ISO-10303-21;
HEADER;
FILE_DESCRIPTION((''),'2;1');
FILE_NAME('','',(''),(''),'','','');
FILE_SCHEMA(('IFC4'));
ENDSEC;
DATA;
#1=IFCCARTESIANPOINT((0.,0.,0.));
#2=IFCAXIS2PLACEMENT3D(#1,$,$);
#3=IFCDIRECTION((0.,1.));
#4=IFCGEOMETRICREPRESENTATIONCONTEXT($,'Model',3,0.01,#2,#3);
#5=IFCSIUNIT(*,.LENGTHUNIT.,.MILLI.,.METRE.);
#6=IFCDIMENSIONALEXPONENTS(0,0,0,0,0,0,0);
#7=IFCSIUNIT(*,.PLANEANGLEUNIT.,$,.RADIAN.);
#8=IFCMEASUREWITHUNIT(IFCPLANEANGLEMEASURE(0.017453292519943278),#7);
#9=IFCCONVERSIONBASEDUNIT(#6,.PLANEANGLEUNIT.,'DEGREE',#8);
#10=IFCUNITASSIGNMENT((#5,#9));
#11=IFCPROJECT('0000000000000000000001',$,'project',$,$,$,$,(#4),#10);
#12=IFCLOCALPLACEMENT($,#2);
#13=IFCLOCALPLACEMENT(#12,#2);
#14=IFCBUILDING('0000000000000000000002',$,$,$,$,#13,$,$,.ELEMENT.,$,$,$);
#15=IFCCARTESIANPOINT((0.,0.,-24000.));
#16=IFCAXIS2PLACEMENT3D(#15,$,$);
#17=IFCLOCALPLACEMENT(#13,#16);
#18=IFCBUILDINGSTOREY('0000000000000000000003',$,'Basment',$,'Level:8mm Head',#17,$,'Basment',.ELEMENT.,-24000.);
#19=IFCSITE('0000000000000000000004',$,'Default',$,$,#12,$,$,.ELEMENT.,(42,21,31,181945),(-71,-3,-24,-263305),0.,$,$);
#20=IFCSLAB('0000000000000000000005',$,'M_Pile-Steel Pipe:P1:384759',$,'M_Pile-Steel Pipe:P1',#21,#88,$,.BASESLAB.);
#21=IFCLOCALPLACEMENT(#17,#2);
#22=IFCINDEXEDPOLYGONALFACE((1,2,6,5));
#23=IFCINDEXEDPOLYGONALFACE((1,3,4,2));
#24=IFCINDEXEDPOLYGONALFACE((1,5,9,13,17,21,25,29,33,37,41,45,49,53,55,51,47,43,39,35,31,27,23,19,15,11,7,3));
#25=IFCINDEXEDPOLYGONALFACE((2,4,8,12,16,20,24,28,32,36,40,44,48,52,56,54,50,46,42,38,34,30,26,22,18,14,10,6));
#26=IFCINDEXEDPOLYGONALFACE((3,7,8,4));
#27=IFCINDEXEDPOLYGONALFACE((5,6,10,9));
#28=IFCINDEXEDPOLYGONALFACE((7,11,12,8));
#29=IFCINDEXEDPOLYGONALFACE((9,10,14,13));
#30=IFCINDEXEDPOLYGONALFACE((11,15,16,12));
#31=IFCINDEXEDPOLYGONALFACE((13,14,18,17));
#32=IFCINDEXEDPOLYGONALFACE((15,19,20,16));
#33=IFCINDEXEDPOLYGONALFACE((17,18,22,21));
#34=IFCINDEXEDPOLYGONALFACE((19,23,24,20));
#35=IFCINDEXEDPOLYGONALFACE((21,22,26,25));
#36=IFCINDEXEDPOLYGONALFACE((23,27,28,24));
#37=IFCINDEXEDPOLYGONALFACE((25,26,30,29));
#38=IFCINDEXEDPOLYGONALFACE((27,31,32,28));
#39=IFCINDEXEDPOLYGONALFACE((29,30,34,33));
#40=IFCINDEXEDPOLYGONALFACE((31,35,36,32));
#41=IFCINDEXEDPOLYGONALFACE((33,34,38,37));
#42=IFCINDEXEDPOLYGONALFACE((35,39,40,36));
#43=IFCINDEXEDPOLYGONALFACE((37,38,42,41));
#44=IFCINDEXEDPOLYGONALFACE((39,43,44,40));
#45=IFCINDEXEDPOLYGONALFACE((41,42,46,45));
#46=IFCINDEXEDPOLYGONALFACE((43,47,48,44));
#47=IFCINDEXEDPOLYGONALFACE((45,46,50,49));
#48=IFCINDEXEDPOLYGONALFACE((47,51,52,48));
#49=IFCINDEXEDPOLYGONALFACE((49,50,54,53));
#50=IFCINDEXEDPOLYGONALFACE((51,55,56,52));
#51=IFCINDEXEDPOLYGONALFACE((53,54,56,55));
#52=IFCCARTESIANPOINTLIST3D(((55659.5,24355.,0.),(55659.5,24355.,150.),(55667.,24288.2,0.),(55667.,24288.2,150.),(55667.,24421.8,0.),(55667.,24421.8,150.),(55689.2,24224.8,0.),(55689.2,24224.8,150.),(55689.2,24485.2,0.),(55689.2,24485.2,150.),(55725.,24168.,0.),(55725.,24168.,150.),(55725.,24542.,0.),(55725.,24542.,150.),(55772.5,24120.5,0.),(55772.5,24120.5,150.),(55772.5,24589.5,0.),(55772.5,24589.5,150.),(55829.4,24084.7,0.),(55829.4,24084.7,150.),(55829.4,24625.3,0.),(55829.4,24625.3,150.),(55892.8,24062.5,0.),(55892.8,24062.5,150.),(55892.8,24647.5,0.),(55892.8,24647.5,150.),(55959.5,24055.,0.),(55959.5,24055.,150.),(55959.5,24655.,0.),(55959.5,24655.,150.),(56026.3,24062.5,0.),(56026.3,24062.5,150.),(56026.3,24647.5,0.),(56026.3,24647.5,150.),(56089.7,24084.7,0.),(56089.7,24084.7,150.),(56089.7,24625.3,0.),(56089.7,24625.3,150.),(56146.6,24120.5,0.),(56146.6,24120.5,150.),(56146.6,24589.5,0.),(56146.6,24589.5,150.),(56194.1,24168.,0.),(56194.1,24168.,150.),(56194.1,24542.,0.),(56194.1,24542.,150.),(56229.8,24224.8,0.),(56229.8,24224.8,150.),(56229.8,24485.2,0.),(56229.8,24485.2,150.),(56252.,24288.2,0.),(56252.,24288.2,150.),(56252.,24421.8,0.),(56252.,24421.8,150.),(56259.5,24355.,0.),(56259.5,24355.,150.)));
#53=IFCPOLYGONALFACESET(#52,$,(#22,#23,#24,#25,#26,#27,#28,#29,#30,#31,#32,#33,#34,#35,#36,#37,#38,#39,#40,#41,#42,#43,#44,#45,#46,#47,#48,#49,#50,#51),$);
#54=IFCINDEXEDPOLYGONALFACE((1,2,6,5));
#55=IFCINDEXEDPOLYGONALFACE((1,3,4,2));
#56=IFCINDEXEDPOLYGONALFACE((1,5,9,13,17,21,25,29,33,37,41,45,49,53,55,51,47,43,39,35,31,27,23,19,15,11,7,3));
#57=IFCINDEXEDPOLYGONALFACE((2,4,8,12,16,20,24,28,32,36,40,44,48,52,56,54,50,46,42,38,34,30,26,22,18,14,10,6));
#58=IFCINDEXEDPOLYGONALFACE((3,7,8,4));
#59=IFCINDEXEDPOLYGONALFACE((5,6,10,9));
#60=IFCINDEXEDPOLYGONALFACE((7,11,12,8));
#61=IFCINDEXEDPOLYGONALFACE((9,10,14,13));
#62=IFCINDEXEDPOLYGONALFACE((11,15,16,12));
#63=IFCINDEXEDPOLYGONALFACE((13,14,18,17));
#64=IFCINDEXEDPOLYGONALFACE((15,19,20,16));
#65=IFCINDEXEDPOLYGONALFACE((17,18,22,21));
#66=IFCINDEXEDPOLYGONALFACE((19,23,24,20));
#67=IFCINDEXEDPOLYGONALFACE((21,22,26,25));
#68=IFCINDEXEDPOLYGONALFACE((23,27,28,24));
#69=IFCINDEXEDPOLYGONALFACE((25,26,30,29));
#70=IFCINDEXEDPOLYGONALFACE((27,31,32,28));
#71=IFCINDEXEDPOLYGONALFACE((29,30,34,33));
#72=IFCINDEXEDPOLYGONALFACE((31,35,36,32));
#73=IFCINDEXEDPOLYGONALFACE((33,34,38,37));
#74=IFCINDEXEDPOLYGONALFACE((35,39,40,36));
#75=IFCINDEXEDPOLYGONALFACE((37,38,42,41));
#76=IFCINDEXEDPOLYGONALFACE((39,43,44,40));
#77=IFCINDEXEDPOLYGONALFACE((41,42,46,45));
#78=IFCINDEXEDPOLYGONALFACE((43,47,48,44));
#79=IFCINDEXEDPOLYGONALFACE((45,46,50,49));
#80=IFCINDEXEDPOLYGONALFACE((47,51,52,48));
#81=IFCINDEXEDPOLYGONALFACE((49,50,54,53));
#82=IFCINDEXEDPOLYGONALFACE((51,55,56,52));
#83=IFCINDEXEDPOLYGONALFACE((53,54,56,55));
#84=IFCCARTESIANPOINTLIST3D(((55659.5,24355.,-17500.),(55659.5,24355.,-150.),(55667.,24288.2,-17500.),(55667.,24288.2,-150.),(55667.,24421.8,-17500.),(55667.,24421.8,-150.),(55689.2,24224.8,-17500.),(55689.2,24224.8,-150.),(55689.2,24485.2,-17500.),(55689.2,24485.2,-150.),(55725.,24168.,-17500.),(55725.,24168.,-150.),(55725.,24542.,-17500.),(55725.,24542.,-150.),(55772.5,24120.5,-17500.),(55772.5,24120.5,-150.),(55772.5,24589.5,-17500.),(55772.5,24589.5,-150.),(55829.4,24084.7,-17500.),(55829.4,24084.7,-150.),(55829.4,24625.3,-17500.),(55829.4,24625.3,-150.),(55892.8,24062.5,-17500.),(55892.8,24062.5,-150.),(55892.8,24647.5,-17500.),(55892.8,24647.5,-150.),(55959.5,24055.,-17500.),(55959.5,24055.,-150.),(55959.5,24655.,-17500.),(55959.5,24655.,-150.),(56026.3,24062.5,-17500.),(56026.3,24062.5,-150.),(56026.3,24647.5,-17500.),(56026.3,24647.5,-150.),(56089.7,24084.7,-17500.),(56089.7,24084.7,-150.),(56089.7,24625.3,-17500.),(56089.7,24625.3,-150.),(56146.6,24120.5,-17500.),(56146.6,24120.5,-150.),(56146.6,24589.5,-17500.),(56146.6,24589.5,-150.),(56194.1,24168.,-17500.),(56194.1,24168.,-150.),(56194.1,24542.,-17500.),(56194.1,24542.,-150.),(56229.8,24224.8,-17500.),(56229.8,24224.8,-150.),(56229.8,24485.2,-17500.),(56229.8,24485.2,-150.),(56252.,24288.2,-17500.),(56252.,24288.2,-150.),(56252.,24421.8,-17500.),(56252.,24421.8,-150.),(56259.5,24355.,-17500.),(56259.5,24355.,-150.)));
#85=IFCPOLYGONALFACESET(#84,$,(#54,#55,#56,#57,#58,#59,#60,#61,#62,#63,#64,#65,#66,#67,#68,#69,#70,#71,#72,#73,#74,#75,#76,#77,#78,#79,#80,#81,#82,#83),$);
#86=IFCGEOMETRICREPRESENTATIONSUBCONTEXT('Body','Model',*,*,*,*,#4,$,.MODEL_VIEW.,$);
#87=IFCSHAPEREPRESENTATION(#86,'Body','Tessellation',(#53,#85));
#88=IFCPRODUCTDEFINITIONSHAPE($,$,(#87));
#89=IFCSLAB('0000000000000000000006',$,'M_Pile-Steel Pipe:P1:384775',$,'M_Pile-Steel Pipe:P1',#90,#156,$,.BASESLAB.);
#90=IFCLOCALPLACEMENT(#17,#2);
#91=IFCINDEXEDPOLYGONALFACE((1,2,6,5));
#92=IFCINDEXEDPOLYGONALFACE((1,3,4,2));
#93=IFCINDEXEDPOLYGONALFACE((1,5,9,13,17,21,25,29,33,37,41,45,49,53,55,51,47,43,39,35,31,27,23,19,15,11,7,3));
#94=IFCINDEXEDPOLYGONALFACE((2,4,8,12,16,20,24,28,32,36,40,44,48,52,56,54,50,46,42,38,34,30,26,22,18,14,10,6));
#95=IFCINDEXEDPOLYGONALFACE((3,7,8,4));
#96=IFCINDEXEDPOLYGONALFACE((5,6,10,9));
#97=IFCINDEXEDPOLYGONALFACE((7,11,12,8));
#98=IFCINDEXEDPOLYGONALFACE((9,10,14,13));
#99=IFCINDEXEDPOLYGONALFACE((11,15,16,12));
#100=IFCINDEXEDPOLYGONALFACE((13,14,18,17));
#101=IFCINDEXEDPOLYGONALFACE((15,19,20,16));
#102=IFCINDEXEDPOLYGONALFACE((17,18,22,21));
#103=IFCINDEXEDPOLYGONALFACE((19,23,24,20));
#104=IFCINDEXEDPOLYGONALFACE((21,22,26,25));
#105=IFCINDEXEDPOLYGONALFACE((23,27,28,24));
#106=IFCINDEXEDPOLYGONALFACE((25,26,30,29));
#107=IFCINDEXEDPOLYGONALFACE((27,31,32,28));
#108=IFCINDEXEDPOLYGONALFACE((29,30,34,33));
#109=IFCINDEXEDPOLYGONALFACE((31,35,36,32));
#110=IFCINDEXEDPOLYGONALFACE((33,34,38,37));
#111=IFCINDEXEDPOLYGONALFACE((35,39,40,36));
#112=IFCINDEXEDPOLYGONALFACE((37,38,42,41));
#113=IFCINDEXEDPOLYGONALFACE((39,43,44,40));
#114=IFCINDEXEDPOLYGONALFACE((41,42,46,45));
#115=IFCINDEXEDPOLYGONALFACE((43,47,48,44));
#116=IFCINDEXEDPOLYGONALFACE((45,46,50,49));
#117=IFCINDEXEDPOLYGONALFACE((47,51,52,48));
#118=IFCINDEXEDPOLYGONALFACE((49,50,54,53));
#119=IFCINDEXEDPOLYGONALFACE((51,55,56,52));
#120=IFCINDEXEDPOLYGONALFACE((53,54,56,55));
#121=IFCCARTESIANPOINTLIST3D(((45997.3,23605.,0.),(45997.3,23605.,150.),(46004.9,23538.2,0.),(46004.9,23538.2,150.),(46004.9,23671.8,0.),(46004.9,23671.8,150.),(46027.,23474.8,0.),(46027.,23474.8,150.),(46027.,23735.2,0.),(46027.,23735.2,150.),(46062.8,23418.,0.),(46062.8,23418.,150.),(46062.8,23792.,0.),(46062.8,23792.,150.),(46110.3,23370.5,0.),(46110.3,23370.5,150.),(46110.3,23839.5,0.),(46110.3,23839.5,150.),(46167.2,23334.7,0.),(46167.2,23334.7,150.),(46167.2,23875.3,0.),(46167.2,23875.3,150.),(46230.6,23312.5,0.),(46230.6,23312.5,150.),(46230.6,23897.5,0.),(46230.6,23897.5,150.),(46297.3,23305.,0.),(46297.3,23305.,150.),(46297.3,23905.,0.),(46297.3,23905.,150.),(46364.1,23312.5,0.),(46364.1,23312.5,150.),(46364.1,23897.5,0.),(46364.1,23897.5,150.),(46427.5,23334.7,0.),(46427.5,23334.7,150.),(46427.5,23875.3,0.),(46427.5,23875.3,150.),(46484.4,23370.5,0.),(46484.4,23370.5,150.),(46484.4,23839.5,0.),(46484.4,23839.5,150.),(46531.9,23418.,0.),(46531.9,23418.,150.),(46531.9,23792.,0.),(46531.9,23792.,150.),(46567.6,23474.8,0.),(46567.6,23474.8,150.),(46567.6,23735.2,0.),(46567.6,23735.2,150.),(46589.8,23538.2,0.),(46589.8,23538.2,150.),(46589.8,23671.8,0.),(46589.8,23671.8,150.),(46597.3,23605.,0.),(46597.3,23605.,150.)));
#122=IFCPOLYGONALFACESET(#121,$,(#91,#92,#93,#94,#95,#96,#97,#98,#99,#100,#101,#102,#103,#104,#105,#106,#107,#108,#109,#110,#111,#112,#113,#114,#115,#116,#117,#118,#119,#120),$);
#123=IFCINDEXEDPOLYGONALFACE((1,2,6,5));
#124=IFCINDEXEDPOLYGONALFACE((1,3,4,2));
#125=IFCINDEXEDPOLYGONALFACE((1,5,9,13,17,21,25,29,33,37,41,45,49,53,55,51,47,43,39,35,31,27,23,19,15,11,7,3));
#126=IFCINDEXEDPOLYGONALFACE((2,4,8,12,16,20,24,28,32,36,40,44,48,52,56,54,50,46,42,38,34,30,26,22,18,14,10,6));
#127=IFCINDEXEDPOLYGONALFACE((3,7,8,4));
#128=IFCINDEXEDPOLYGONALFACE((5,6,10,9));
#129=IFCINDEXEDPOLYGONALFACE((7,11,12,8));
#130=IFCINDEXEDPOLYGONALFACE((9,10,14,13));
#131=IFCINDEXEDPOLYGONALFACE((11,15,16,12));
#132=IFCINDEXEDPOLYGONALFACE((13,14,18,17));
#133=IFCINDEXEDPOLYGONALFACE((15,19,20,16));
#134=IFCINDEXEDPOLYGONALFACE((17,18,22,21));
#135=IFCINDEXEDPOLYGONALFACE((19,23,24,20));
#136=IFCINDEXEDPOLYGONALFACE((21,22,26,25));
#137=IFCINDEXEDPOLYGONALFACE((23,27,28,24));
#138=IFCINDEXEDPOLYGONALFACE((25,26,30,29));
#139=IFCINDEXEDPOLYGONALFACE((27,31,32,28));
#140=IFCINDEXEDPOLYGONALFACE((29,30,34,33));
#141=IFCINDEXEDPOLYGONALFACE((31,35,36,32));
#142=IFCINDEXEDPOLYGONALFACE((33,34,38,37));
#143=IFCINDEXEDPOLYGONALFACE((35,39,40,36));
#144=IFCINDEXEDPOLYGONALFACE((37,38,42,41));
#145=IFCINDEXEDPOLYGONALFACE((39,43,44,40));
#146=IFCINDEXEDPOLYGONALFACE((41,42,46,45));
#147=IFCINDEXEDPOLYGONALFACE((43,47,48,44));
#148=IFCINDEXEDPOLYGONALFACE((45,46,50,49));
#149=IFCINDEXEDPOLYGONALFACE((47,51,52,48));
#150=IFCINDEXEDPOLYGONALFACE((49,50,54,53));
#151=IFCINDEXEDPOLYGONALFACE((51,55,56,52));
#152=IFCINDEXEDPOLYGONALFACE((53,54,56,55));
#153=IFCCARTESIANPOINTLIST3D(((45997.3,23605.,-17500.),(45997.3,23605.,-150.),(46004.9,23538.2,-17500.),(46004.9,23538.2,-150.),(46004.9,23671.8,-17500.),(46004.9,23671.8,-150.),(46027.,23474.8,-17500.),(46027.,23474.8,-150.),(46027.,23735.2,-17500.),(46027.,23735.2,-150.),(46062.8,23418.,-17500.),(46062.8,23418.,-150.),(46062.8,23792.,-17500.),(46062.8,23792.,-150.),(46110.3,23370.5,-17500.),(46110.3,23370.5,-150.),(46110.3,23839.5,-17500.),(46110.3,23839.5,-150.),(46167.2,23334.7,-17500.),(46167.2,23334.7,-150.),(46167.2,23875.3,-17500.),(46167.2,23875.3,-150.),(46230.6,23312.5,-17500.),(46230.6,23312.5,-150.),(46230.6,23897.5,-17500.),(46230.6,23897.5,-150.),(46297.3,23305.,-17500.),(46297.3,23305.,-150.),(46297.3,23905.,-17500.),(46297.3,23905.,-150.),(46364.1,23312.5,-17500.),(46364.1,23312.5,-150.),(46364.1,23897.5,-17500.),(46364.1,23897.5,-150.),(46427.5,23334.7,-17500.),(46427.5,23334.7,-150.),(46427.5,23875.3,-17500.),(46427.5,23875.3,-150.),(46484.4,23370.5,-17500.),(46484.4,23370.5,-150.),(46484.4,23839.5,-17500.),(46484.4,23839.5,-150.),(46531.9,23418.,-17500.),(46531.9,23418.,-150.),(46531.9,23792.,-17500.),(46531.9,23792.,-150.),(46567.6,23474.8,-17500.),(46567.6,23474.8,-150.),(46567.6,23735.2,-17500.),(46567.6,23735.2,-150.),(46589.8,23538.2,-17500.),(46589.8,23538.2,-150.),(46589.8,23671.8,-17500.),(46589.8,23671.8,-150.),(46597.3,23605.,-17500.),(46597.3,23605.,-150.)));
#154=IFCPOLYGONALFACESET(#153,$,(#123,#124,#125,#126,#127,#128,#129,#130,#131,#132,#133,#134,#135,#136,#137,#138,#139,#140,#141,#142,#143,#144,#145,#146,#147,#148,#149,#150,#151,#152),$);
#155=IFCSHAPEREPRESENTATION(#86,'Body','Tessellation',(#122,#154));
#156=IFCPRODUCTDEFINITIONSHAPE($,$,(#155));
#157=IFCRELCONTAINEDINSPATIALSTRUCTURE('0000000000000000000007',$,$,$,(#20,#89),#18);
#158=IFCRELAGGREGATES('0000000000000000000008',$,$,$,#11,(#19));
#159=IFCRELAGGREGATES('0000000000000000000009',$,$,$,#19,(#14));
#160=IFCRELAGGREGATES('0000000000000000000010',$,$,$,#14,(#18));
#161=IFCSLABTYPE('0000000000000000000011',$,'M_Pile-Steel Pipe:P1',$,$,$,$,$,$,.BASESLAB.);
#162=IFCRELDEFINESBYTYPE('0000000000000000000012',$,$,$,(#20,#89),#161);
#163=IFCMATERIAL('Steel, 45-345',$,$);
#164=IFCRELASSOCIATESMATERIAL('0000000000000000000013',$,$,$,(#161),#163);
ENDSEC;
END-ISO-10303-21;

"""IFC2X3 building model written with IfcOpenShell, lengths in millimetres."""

from ifc_helpers import new_model, entity, si_unit, converted_unit, direction, frame, origin, origin_2d_with_axis, place, context, subcontext, project, spatial, circle, extrude, material, type_object, element, save


model = new_model("IFC2X3")

# Units and contexts
model_context = context("Model", 3, precision=0.01, world=origin(), true_north=direction((0.0, 1.0)))
body_context = subcontext(model_context, "Body", "Model", "MODEL_VIEW")
ifc_project = project(units=[si_unit("LENGTHUNIT", "METRE", prefix="MILLI"), converted_unit("PLANEANGLEUNIT", "DEGREE", entity("IfcPlaneAngleMeasure", 0.017453292519943278), si_unit("PLANEANGLEUNIT", "RADIAN"), dimensions=[0, 0, 0, 0, 0, 0, 0])], contexts=[model_context])

# Site, building, storey
site_placement = place(None, origin())
site = spatial("IfcSite", under=ifc_project, at=site_placement, Name="Default", CompositionType="ELEMENT", RefLatitude=(42, 21, 31, 181945), RefLongitude=(-71, -3, -24, -263305), RefElevation=0.0)
building_placement = place(site_placement, origin())
building = spatial("IfcBuilding", under=site, at=building_placement, CompositionType="ELEMENT")
storey_placement = place(building_placement, frame((0.0, 0.0, -24000.0)))
storey = spatial("IfcBuildingStorey", under=building, at=storey_placement, Name="Basment", ObjectType="Level:8mm Head", LongName="Basment", CompositionType="ELEMENT", Elevation=-24000.0)

# Slabs
ifc_material_1 = material(Name="Steel, 45-345")
slab_type_1 = type_object("IfcSlabType", Name="M_Pile-Steel Pipe:P1", PredefinedType="BASESLAB", material=ifc_material_1)
slab_1_placement = place(storey_placement, origin())
element("IfcSlab", 1, at=slab_1_placement, inside=storey, type_object=slab_type_1, Name="M_Pile-Steel Pipe:P1:384759", ObjectType="M_Pile-Steel Pipe:P1", PredefinedType="BASESLAB", context=body_context, shape_type="SweptSolid", body=[
    extrude(circle(Radius=300.0, at=origin_2d_with_axis()), frame((55959.5, 24355.0, 0.0), z_axis=(0.0, 0.0, 1.0), x_axis=(0.0, 1.0, 0.0)), (0.0, 0.0, 1.0), 150.0),
    extrude(circle(Radius=300.0, at=origin_2d_with_axis()), frame((55959.5, 24355.0, -17500.0), z_axis=(0.0, 0.0, 1.0), x_axis=(0.0, 1.0, 0.0)), (0.0, 0.0, 1.0), 17350.0),
])
slab_2_placement = place(storey_placement, origin())
element("IfcSlab", 2, at=slab_2_placement, inside=storey, type_object=slab_type_1, Name="M_Pile-Steel Pipe:P1:384775", ObjectType="M_Pile-Steel Pipe:P1", PredefinedType="BASESLAB", context=body_context, shape_type="SweptSolid", body=[
    extrude(circle(Radius=300.0, at=origin_2d_with_axis()), frame((46297.3, 23605.0, 0.0), z_axis=(0.0, 0.0, 1.0), x_axis=(0.0, 1.0, 0.0)), (0.0, 0.0, 1.0), 150.0),
    extrude(circle(Radius=300.0, at=origin_2d_with_axis()), frame((46297.3, 23605.0, -17500.0), z_axis=(0.0, 0.0, 1.0), x_axis=(0.0, 1.0, 0.0)), (0.0, 0.0, 1.0), 17350.0),
])

save(model, "model.ifc")
